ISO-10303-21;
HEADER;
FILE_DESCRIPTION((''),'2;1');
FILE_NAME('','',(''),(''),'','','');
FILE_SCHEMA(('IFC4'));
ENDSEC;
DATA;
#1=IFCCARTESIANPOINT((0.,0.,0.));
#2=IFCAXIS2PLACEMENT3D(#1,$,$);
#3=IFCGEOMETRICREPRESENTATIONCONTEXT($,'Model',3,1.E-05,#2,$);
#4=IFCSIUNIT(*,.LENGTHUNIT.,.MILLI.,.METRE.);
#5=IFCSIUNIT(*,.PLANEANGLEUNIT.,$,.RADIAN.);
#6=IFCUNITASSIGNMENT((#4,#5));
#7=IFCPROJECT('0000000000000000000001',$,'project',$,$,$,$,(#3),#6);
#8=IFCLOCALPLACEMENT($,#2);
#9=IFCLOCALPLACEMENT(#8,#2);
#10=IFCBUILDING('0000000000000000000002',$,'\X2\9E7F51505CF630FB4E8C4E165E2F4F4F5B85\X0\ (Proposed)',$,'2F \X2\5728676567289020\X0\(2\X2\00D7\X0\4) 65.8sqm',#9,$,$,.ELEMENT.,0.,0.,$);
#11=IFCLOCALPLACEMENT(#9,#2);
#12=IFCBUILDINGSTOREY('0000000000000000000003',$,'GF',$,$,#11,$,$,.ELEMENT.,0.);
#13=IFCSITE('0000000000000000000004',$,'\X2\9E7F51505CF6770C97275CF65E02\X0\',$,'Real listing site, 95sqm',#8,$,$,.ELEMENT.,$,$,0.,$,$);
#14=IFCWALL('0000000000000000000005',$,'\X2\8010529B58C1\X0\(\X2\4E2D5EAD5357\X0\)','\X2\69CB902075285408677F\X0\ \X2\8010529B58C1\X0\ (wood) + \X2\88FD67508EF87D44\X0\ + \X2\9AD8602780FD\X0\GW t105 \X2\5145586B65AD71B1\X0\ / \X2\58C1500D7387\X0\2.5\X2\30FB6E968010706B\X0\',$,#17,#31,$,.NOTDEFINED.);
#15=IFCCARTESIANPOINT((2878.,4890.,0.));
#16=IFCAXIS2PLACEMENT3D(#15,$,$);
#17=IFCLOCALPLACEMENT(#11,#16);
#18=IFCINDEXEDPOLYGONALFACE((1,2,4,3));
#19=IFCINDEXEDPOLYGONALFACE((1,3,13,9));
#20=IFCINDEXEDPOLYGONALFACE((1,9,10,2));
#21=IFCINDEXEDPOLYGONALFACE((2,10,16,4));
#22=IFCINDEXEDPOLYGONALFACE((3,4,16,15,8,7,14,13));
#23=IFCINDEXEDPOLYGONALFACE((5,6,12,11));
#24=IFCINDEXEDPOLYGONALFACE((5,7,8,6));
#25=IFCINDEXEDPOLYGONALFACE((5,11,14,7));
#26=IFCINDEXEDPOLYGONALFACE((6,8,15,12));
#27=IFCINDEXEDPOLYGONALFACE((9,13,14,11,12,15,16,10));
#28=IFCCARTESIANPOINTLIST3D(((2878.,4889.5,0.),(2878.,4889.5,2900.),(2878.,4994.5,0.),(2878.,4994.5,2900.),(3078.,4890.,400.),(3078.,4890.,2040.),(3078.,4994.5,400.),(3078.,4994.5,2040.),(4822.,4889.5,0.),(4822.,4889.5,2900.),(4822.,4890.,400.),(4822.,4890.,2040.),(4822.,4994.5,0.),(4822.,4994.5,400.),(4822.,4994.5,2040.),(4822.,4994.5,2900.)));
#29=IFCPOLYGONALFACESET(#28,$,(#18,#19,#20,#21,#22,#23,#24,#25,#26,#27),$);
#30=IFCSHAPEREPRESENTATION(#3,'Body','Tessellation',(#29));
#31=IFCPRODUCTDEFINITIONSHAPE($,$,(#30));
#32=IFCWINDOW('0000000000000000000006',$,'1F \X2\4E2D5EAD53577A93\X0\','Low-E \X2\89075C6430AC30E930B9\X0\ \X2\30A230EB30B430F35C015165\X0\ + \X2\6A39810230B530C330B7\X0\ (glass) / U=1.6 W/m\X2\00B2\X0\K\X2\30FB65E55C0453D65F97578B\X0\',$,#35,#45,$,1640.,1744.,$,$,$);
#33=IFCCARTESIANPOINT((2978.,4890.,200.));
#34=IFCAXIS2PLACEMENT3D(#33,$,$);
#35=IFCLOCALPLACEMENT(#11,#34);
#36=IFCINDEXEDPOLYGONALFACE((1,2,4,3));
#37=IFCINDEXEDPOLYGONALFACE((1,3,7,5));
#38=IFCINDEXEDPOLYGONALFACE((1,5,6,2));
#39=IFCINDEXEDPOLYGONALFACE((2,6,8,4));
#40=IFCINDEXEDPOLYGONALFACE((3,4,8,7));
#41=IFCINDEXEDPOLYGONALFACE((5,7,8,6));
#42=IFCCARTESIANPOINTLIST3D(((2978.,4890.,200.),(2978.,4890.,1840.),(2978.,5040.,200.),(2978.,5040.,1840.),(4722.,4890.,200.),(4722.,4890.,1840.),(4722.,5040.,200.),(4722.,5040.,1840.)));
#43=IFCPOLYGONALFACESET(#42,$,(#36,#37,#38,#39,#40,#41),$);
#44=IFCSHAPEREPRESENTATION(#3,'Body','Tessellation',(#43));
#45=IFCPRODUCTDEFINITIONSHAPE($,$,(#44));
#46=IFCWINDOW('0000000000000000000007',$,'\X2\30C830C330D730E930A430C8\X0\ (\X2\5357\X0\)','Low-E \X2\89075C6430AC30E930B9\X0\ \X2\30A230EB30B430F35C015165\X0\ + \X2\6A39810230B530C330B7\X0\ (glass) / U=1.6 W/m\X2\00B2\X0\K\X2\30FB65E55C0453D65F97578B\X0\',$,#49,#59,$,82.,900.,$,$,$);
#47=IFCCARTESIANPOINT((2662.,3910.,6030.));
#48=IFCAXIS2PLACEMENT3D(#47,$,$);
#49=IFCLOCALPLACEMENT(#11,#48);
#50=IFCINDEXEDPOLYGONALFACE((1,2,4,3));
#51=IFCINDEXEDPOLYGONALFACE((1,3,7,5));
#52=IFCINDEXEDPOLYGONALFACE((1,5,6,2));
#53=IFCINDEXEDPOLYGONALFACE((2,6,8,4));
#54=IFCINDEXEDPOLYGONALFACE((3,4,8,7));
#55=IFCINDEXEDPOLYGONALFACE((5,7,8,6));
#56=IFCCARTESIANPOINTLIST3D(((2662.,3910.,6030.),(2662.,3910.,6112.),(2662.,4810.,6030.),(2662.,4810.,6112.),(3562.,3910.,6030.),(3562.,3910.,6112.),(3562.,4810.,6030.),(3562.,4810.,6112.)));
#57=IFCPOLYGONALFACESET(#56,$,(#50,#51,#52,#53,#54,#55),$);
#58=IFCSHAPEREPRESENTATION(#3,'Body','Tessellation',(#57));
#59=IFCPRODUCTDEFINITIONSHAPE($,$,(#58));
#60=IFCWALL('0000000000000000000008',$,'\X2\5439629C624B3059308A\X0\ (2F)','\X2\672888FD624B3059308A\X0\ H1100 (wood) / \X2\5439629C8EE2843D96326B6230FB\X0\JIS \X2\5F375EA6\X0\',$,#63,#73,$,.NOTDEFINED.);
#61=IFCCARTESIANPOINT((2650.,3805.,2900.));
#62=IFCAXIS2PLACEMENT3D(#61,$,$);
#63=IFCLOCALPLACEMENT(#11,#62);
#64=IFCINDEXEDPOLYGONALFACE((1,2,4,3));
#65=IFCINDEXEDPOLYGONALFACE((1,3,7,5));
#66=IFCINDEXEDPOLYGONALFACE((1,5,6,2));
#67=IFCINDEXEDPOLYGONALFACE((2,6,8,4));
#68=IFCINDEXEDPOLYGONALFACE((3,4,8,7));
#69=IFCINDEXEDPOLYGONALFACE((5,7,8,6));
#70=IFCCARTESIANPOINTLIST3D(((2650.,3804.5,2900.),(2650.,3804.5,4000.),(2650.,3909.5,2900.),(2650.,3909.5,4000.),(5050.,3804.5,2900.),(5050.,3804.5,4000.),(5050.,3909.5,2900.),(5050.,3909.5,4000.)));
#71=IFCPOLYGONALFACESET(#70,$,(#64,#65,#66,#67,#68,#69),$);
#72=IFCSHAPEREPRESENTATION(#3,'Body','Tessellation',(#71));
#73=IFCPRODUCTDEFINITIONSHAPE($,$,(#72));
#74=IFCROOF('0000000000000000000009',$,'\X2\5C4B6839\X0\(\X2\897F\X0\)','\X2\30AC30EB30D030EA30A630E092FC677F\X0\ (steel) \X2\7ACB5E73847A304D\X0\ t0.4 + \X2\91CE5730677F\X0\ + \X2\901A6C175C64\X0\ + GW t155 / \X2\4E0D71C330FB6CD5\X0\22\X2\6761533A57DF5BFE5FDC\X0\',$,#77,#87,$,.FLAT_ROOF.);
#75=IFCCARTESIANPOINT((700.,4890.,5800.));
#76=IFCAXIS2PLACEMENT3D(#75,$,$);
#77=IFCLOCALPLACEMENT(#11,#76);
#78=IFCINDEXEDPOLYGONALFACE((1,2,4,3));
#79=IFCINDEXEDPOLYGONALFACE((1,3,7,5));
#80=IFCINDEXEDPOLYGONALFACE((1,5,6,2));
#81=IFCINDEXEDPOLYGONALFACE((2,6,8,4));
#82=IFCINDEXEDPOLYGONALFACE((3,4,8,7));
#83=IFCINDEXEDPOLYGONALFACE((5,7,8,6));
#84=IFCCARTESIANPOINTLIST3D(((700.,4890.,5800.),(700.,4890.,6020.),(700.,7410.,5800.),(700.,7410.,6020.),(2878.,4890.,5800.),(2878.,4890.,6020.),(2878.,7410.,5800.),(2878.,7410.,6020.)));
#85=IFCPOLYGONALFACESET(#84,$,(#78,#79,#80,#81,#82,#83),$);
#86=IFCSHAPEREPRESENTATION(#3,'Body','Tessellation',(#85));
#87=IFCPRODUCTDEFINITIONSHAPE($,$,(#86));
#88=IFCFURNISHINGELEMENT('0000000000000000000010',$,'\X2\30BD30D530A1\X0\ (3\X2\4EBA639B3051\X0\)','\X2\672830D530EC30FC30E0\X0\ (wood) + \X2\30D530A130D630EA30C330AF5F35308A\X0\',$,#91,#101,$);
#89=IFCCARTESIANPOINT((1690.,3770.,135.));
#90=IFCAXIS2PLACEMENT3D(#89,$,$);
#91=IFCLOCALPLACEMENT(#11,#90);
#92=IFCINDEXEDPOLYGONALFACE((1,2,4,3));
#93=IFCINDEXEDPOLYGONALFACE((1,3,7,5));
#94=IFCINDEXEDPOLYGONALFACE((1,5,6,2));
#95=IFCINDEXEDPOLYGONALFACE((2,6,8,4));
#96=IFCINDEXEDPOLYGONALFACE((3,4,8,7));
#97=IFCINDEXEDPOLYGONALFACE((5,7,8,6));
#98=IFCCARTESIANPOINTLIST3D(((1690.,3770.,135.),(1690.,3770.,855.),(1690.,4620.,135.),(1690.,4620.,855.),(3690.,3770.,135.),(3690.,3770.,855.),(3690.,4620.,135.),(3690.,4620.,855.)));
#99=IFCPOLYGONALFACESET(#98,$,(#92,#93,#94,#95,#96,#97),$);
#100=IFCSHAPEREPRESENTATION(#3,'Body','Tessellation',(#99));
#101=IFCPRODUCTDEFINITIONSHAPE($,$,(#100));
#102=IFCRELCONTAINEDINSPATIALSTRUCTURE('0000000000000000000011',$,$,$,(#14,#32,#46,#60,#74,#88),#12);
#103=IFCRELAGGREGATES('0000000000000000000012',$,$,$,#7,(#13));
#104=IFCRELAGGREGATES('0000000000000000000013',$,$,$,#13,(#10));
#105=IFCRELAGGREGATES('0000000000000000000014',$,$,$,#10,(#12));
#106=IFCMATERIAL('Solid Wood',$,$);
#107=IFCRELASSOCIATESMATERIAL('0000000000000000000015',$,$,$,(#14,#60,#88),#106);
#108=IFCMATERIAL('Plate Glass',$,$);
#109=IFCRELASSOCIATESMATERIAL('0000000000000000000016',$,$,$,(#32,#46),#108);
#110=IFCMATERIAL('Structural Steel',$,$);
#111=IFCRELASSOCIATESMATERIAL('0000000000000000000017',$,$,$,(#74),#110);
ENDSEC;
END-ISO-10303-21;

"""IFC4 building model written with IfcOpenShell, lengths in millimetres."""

from ifc_helpers import new_model, si_unit, frame, frame_2d, origin, place, context, project, spatial, rectangle, extrude, material, element, fill, save


model = new_model("IFC4")

# Units and contexts
model_context = context("Model", 3, precision=1e-05, world=origin())
ifc_project = project(units=[si_unit("LENGTHUNIT", "METRE", prefix="MILLI"), si_unit("PLANEANGLEUNIT", "RADIAN")], contexts=[model_context])

# Site, building, storey
site_placement = place(None, origin())
site = spatial("IfcSite", under=ifc_project, at=site_placement, Name="鹿児島県霧島市", ObjectType="Real listing site, 95sqm", CompositionType="ELEMENT", RefElevation=0.0)
building_placement = place(site_placement, origin())
building = spatial("IfcBuilding", under=site, at=building_placement, Name="鹿児島・二世帯住宅 (Proposed)", ObjectType="2F 在来木造(2×4) 65.8sqm", CompositionType="ELEMENT", ElevationOfRefHeight=0.0, ElevationOfTerrain=0.0)
storey_placement = place(building_placement, origin())
storey = spatial("IfcBuildingStorey", under=building, at=storey_placement, Name="GF", CompositionType="ELEMENT", Elevation=0.0)

# Shared definitions
ifc_material_1 = material(Name="Solid Wood")

# Wall, opening, window
wall_1_placement = place(storey_placement, frame((2878.0, 4890.0, 0.0)))
wall_1 = element("IfcWall", 1, at=wall_1_placement, inside=storey, material=ifc_material_1, Name="耐力壁(中庭南)", Description="構造用合板 耐力壁 (wood) + 製材軸組 + 高性能GW t105 充填断熱 / 壁倍率2.5・準耐火", PredefinedType="NOTDEFINED", context=model_context, shape_type="SweptSolid", body=[
    extrude(rectangle(XDim=1944.0, YDim=105.0, at=frame_2d((972.0, 52.0))), frame((2878.0, 4890.0, 0.0)), (0.0, 0.0, 1.0), 2900.0),
])
opening_placement = place(storey_placement, frame((2978.0, 4890.0, 200.0)))
opening = element("IfcOpeningElement", 2, at=opening_placement, cuts=wall_1, PredefinedType="NOTDEFINED", context=model_context, shape_type="SweptSolid", body=[
    extrude(rectangle(XDim=1744.0, YDim=150.0, at=frame_2d((872.0, 75.0))), frame((2978.0, 4890.0, 200.0)), (0.0, 0.0, 1.0), 1640.0),
])
ifc_material_2 = material(Name="Plate Glass")
window_1_placement = place(storey_placement, frame((2978.0, 4890.0, 200.0)))
window_1 = element("IfcWindow", 3, at=window_1_placement, inside=storey, material=ifc_material_2, Name="1F 中庭南窓", Description="Low-E 複層ガラス アルゴン封入 + 樹脂サッシ (glass) / U=1.6 W/m²K・日射取得型", OverallHeight=1640.0, OverallWidth=1744.0, context=model_context, shape_type="SweptSolid", body=[
    extrude(rectangle(XDim=1744.0, YDim=150.0, at=frame_2d((872.0, 75.0))), frame((2978.0, 4890.0, 200.0)), (0.0, 0.0, 1.0), 1640.0),
])
fill(opening, window_1)

# Window
window_2_placement = place(storey_placement, frame((2662.0, 3910.0, 6030.0)))
element("IfcWindow", 4, at=window_2_placement, inside=storey, material=ifc_material_2, Name="トップライト (南)", Description="Low-E 複層ガラス アルゴン封入 + 樹脂サッシ (glass) / U=1.6 W/m²K・日射取得型", OverallHeight=82.0, OverallWidth=900.0, context=model_context, shape_type="SweptSolid", body=[
    extrude(rectangle(XDim=900.0, YDim=900.0, at=frame_2d((450.0, 450.0))), frame((2662.0, 3910.0, 6030.0)), (0.0, 0.0, 1.0), 82.0),
])

# Wall
wall_2_placement = place(storey_placement, frame((2650.0, 3805.0, 2900.0)))
element("IfcWall", 5, at=wall_2_placement, inside=storey, material=ifc_material_1, Name="吹抜手すり (2F)", Description="木製手すり H1100 (wood) / 吹抜転落防止・JIS 強度", PredefinedType="NOTDEFINED", context=model_context, shape_type="SweptSolid", body=[
    extrude(rectangle(XDim=2400.0, YDim=105.0, at=frame_2d((1200.0, 52.0))), frame((2650.0, 3805.0, 2900.0)), (0.0, 0.0, 1.0), 1100.0),
])

# Roof
ifc_material_3 = material(Name="Structural Steel")
for number, where, name in (
    (6, (700.0, 4890.0, 5800.0), "屋根(西)"),
):
    element("IfcRoof", number, at=place(storey_placement, frame(where)), inside=storey, material=ifc_material_3, Name=name, Description="ガルバリウム鋼板 (steel) 立平葺き t0.4 + 野地板 + 通気層 + GW t155 / 不燃・法22条区域対応", PredefinedType="FLAT_ROOF", context=model_context, shape_type="SweptSolid", body=[
        extrude(rectangle(XDim=2178.0, YDim=2520.0, at=frame_2d((1089.0, 1260.0))), frame((700.0, 4890.0, 5800.0)), (0.0, 0.0, 1.0), 220.0),
    ])

# Furnishing element
furnishing_placement = place(storey_placement, frame((1690.0, 3770.0, 135.0)))
element("IfcFurnishingElement", 7, at=furnishing_placement, inside=storey, material=ifc_material_1, Name="ソファ (3人掛け)", Description="木フレーム (wood) + ファブリック張り", context=model_context, shape_type="SweptSolid", body=[
    extrude(rectangle(XDim=2000.0, YDim=850.0, at=frame_2d((1000.0, 425.0))), frame((1690.0, 3770.0, 135.0)), (0.0, 0.0, 1.0), 720.0),
])

save(model, "model.ifc")
